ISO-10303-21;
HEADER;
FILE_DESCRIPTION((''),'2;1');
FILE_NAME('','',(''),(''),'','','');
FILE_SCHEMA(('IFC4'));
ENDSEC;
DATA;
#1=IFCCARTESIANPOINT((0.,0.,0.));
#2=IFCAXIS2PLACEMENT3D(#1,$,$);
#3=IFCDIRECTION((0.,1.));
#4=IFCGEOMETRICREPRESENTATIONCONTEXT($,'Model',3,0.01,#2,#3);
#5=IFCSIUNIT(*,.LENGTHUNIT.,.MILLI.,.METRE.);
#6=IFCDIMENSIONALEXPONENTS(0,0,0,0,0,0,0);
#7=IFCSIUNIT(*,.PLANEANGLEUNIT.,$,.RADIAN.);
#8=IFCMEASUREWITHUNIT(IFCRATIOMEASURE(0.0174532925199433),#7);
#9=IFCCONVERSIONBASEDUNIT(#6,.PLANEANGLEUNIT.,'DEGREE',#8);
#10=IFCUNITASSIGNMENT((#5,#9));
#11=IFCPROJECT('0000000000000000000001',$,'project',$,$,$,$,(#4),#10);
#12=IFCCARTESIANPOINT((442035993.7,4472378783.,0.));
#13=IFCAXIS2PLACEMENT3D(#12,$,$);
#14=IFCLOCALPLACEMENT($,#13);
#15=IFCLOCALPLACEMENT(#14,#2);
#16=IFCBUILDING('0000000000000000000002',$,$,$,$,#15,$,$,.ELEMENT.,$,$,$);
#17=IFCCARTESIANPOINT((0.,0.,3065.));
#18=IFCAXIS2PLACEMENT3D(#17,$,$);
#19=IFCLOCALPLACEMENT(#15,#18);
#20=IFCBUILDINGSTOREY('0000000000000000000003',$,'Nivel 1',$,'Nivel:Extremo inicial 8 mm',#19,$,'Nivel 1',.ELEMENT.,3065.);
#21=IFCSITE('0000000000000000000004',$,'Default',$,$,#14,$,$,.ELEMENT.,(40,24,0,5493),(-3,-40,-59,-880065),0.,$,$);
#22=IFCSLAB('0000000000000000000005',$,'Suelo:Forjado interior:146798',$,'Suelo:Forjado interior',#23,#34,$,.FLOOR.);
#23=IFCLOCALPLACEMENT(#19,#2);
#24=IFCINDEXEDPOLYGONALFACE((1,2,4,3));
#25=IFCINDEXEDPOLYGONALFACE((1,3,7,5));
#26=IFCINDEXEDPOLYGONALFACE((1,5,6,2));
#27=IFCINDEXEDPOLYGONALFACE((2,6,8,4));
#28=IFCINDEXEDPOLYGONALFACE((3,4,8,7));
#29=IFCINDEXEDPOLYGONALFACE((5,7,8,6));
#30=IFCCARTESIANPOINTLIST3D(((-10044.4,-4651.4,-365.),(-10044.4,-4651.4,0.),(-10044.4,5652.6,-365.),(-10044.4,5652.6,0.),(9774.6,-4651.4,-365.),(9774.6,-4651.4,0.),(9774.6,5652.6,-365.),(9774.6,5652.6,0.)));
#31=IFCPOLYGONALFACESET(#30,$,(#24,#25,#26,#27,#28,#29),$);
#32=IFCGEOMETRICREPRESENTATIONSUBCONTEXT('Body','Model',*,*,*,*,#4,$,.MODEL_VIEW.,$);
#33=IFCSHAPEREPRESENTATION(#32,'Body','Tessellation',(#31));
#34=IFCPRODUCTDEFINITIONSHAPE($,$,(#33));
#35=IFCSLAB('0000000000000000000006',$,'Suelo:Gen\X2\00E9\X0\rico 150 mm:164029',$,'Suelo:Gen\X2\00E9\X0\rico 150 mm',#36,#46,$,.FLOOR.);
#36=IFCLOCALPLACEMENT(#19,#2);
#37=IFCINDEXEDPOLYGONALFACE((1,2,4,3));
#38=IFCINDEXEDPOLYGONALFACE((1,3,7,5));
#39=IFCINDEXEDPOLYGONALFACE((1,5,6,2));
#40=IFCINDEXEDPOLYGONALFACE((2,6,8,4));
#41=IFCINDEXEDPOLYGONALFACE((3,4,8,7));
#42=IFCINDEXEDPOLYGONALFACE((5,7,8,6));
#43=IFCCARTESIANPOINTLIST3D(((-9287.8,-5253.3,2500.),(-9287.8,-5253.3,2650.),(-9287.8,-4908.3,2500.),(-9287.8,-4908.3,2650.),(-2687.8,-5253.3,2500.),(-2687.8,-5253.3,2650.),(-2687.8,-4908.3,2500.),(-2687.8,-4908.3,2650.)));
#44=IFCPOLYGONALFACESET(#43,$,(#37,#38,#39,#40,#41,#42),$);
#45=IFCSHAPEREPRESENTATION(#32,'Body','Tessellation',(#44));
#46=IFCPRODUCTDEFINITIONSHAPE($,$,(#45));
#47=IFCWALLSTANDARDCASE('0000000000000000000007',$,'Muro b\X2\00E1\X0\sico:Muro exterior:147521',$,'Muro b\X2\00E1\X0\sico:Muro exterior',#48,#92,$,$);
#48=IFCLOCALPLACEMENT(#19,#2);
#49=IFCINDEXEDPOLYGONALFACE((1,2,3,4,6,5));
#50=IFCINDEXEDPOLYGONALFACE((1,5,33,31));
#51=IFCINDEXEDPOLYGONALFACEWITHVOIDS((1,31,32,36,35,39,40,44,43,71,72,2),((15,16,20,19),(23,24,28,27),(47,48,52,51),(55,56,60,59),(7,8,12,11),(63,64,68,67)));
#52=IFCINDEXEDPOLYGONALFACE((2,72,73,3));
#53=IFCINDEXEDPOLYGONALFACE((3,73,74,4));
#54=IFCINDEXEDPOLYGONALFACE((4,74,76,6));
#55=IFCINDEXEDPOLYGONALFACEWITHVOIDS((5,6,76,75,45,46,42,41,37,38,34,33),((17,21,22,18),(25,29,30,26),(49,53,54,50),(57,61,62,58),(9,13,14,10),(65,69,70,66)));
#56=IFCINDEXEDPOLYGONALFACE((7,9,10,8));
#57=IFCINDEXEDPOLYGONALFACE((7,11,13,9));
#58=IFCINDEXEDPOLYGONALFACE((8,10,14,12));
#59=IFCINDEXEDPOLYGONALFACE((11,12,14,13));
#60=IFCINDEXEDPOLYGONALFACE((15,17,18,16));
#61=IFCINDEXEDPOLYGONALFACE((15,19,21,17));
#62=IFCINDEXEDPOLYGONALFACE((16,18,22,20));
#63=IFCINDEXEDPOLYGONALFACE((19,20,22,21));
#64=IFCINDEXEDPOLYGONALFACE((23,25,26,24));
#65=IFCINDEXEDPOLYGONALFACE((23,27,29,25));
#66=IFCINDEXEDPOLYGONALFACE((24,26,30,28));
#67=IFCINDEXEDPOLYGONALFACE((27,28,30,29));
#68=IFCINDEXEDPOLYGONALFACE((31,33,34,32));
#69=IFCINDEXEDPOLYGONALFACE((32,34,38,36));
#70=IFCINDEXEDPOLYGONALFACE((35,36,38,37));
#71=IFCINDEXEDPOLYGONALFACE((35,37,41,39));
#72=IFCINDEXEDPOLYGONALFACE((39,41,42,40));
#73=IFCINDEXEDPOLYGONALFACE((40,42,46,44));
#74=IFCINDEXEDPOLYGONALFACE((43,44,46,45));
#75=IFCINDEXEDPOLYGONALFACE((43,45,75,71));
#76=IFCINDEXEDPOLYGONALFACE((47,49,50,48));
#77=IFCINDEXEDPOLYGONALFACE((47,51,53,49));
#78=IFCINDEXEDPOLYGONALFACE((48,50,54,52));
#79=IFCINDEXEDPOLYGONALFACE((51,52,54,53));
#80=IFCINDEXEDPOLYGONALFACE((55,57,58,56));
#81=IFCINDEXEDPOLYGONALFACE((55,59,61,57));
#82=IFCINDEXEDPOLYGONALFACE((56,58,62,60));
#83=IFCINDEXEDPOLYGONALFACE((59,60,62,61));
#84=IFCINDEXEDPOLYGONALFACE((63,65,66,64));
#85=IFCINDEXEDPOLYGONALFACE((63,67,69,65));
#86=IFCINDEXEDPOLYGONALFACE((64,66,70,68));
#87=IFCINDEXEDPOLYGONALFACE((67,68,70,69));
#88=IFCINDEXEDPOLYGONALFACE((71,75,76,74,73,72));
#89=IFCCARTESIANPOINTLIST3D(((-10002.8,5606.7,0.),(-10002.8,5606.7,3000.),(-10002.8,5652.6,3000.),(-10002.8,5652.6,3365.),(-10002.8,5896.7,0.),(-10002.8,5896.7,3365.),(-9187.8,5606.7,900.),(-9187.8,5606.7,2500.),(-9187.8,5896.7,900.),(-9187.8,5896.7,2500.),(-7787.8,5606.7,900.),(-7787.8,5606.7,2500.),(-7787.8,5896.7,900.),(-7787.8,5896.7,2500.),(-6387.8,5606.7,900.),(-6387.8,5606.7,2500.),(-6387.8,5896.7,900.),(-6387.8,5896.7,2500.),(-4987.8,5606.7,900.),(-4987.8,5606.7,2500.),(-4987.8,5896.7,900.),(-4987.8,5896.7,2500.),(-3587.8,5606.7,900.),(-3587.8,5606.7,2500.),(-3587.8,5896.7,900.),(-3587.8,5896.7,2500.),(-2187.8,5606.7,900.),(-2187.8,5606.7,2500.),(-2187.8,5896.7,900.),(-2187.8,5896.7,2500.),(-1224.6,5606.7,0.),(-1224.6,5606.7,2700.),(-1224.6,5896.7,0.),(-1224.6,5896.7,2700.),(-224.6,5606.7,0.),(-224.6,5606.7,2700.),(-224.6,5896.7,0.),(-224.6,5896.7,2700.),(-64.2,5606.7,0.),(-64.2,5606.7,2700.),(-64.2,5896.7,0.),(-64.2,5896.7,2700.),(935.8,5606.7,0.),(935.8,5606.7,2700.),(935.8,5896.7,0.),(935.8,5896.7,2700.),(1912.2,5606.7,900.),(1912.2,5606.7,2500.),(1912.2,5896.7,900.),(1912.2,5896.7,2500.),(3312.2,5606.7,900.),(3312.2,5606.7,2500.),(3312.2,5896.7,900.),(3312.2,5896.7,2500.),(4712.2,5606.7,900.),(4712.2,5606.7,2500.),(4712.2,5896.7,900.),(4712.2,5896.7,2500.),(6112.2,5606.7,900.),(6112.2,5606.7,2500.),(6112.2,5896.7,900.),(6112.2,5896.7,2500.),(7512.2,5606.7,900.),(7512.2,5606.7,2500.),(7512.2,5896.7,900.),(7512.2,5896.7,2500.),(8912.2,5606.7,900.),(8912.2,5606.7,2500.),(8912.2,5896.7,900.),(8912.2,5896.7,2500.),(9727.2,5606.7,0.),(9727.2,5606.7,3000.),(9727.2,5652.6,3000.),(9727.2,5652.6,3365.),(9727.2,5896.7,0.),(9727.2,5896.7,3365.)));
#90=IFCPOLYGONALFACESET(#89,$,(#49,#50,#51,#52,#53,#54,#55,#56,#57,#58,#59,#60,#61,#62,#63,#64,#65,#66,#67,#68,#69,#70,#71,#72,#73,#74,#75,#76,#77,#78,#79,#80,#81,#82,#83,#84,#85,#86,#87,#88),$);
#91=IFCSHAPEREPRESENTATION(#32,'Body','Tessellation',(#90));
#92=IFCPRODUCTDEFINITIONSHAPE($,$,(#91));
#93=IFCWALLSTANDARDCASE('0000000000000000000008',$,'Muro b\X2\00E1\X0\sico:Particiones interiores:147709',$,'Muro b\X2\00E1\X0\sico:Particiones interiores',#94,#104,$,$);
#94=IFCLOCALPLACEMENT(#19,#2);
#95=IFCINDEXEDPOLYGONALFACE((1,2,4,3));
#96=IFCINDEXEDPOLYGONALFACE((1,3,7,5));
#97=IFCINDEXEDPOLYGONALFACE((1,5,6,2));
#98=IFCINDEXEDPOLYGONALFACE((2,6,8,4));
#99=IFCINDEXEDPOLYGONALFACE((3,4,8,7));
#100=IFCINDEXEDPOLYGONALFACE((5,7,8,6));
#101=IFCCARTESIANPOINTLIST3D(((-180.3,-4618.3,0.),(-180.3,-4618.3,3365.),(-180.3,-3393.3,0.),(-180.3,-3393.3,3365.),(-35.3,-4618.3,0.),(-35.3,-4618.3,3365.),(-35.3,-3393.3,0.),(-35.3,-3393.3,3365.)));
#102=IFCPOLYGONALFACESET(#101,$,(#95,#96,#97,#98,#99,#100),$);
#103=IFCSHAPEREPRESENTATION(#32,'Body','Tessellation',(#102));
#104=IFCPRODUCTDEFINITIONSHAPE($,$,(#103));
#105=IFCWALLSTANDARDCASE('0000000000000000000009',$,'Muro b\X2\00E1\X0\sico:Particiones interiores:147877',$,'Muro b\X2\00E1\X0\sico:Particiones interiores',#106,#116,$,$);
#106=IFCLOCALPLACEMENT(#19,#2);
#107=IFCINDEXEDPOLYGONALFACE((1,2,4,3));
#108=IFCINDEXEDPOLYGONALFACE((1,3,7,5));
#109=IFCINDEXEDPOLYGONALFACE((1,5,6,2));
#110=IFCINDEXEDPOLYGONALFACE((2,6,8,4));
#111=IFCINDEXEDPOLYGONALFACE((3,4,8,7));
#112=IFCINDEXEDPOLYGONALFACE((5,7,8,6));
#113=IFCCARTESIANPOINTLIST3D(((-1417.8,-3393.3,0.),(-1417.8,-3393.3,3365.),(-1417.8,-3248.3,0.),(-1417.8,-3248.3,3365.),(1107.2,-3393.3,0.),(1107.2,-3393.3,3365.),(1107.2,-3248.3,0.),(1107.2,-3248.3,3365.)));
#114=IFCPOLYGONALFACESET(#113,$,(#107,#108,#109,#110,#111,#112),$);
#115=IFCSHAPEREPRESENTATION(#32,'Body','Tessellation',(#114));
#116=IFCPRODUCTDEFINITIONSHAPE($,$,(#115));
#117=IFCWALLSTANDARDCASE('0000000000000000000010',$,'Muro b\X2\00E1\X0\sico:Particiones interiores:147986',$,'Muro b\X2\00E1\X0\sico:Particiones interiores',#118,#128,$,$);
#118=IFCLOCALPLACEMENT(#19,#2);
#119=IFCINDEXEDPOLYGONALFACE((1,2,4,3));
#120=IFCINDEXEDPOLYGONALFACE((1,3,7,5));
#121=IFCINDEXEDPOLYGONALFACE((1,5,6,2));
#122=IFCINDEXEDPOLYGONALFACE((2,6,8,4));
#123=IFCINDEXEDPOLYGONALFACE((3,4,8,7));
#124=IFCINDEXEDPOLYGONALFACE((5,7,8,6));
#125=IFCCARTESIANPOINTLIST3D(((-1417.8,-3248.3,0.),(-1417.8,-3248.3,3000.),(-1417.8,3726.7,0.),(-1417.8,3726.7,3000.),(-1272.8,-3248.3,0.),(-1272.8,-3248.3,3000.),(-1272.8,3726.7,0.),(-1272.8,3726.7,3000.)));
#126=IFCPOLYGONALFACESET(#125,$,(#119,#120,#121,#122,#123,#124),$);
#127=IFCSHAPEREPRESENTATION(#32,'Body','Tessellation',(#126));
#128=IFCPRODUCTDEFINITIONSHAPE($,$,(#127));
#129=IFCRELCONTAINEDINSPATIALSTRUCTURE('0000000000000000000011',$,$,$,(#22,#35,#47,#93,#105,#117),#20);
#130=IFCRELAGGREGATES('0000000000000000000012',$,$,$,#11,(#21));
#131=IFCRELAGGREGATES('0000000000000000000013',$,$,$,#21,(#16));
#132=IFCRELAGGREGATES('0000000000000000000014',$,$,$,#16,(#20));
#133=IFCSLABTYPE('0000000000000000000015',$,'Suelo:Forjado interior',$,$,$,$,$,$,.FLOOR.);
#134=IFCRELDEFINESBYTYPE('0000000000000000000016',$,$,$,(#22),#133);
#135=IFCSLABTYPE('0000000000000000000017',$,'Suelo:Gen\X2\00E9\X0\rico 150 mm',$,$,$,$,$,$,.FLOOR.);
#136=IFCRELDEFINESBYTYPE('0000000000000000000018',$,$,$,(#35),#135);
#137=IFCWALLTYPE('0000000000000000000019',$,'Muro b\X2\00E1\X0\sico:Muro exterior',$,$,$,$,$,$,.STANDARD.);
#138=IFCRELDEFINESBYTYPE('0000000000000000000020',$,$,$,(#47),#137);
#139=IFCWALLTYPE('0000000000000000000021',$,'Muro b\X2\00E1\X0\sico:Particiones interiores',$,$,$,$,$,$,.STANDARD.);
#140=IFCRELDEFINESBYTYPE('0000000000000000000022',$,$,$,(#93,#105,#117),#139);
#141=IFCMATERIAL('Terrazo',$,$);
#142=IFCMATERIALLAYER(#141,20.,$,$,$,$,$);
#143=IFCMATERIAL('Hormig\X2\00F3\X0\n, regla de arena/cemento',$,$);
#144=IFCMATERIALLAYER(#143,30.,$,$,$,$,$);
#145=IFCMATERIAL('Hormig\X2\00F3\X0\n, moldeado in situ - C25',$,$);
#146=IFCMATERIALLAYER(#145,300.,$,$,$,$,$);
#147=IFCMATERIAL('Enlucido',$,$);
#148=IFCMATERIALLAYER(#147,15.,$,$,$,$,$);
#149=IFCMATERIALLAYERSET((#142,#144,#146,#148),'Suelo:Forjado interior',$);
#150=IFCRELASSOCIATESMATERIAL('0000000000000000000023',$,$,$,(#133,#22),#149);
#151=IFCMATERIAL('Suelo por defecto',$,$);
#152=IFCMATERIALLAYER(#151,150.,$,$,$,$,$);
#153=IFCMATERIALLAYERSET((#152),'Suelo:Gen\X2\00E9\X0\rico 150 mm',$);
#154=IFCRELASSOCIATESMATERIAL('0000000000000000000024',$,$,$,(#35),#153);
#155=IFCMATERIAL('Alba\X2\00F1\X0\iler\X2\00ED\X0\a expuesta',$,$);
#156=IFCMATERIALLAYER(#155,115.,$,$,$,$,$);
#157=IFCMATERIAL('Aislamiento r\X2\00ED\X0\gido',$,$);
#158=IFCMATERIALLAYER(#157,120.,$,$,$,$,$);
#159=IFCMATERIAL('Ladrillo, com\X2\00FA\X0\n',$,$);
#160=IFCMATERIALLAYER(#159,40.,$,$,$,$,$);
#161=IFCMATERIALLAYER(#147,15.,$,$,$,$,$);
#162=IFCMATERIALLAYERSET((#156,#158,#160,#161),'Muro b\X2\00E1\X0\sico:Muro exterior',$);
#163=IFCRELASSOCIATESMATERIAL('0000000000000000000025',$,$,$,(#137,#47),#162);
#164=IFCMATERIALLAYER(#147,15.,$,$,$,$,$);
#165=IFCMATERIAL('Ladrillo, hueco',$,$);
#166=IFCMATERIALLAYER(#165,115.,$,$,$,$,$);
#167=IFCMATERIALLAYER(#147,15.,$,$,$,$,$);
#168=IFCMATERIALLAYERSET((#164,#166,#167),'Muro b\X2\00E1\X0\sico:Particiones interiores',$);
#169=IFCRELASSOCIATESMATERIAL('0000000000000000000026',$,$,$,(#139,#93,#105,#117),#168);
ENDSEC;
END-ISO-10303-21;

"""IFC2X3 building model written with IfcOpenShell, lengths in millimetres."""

from ifc_helpers import new_model, entity, si_unit, converted_unit, direction, frame, frame_2d, origin, origin_2d_with_axis, place, context, subcontext, project, spatial, polyline, rectangle, extrude, clip, bounded_halfspace, material, layer, layer_set, layer_usage, type_object, element, save


model = new_model("IFC2X3")

# Units and contexts
model_context = context("Model", 3, precision=0.01, world=origin(), true_north=direction((0.0, 1.0)))
body_context = subcontext(model_context, "Body", "Model", "MODEL_VIEW")
ifc_project = project(units=[si_unit("LENGTHUNIT", "METRE", prefix="MILLI"), converted_unit("PLANEANGLEUNIT", "DEGREE", entity("IfcRatioMeasure", 0.0174532925199433), si_unit("PLANEANGLEUNIT", "RADIAN"), dimensions=[0, 0, 0, 0, 0, 0, 0])], contexts=[model_context])

# Site, building, storey
site_placement = place(None, frame((442035993.7, 4472378783.0, 0.0)))
site = spatial("IfcSite", under=ifc_project, at=site_placement, Name="Default", CompositionType="ELEMENT", RefLatitude=(40, 24, 0, 5493), RefLongitude=(-3, -40, -59, -880065), RefElevation=0.0)
building_placement = place(site_placement, origin())
building = spatial("IfcBuilding", under=site, at=building_placement, CompositionType="ELEMENT")
storey_placement = place(building_placement, frame((0.0, 0.0, 3065.0)))
storey = spatial("IfcBuildingStorey", under=building, at=storey_placement, Name="Nivel 1", ObjectType="Nivel:Extremo inicial 8 mm", LongName="Nivel 1", CompositionType="ELEMENT", Elevation=3065.0)

# Slabs
ifc_material_1 = material(Name="Terrazo")
ifc_layer_1 = layer(ifc_material_1, 20.0)
ifc_material_2 = material(Name="Hormigón, regla de arena/cemento")
ifc_layer_2 = layer(ifc_material_2, 30.0)
ifc_material_3 = material(Name="Hormigón, moldeado in situ - C25")
ifc_layer_3 = layer(ifc_material_3, 300.0)
ifc_material_4 = material(Name="Enlucido")
ifc_layer_4 = layer(ifc_material_4, 15.0)
ifc_layer_set_1 = layer_set([ifc_layer_1, ifc_layer_2, ifc_layer_3, ifc_layer_4], Name="Suelo:Forjado interior")
ifc_layer_usage_1 = layer_usage(ifc_layer_set_1, "AXIS3", "POSITIVE", 0.0)
slab_type_1 = type_object("IfcSlabType", Name="Suelo:Forjado interior", PredefinedType="FLOOR", material=ifc_layer_set_1)
slab_1_placement = place(storey_placement, origin())
element("IfcSlab", 1, at=slab_1_placement, inside=storey, type_object=slab_type_1, material=ifc_layer_usage_1, Name="Suelo:Forjado interior:146798", ObjectType="Suelo:Forjado interior", PredefinedType="FLOOR", context=body_context, shape_type="SweptSolid", body=[
    extrude(rectangle(XDim=10304.0, YDim=19819.0, at=origin_2d_with_axis()), frame((-134.9, 500.6, 0.0), z_axis=(0.0, 0.0, -1.0), x_axis=(0.0, 1.0, 0.0)), (0.0, 0.0, 1.0), 365.0),
])
ifc_material_5 = material(Name="Suelo por defecto")
ifc_layer_5 = layer(ifc_material_5, 150.0)
ifc_layer_set_2 = layer_set([ifc_layer_5], Name="Suelo:Genérico 150 mm")
ifc_layer_usage_2 = layer_usage(ifc_layer_set_2, "AXIS3", "POSITIVE", 0.0)
slab_type_2 = type_object("IfcSlabType", Name="Suelo:Genérico 150 mm", PredefinedType="FLOOR")
slab_2_placement = place(storey_placement, frame((-9287.8, -5253.3, 2500.0)))
element("IfcSlab", 2, at=slab_2_placement, inside=storey, type_object=slab_type_2, material=ifc_layer_usage_2, Name="Suelo:Genérico 150 mm:164029", ObjectType="Suelo:Genérico 150 mm", PredefinedType="FLOOR", context=body_context, shape_type="SweptSolid", body=[
    extrude(rectangle(XDim=6600.0, YDim=345.0, at=frame_2d((5850.0, 0.0), x_axis=(1.0, 0.0))), frame((9150.0, 172.5, 150.0), z_axis=(0.0, 0.0, -1.0), x_axis=(-1.0, 0.0, 0.0)), (0.0, 0.0, 1.0), 150.0),
])

# Wall, openings
ifc_material_6 = material(Name="Albañilería expuesta")
ifc_layer_6 = layer(ifc_material_6, 115.0)
ifc_material_7 = material(Name="Aislamiento rígido")
ifc_layer_7 = layer(ifc_material_7, 120.0)
ifc_material_8 = material(Name="Ladrillo, común")
ifc_layer_8 = layer(ifc_material_8, 40.0)
ifc_layer_9 = layer(ifc_material_4, 15.0)
ifc_layer_set_3 = layer_set([ifc_layer_6, ifc_layer_7, ifc_layer_8, ifc_layer_9], Name="Muro básico:Muro exterior")
ifc_layer_usage_3 = layer_usage(ifc_layer_set_3, "AXIS2", "NEGATIVE", 145.0)
wall_type_1 = type_object("IfcWallType", Name="Muro básico:Muro exterior", PredefinedType="STANDARD", material=ifc_layer_set_3)
wall_1_placement = place(storey_placement, frame((-10002.8, 5751.7, 0.0)))
wall_1 = element("IfcWallStandardCase", 3, at=wall_1_placement, inside=storey, type_object=wall_type_1, material=ifc_layer_usage_3, Name="Muro básico:Muro exterior:147521", ObjectType="Muro básico:Muro exterior", context=body_context, shape_type="Clipping", body=[
    clip(clip(extrude(rectangle(XDim=19730.0, YDim=290.0, at=frame_2d((9865.0, 0.0), x_axis=(-1.0, 0.0))), origin(), (0.0, 0.0, 1.0), 3365.0), bounded_halfspace(frame((19730.0, -99.2, 3000.0), z_axis=(0.0, 0.0, -1.0), x_axis=(-1.0, 0.0, 0.0)), True, frame((19730.0, -99.2, 3000.0), z_axis=(0.0, 0.0, -1.0), x_axis=(-1.0, 0.0, 0.0)), polyline([(0.0, 0.0), (0.0, -45.8), (9791.4, -45.8), (9936.4, -45.8), (19730.0, -45.8), (19730.0, 0.0), (0.0, 0.0)]))), bounded_halfspace(frame((0.0, -99.2, 3000.0), z_axis=(0.0, 1.0, 0.0), x_axis=(0.0, 0.0, 1.0)), True, frame((0.0, -99.2, 3000.0), z_axis=(0.0, 1.0, 0.0), x_axis=(0.0, 0.0, 1.0)), polyline([(0.0, 0.0), (365.0, 0.0), (365.0, 19730.0), (0.0, 19730.0), (0.0, 0.0)]))),
])
opening_1_placement = place(wall_1_placement, origin())
element("IfcOpeningElement", 4, at=opening_1_placement, cuts=wall_1, ObjectType="Opening", context=body_context, shape_type="SweptSolid", body=[
    extrude(rectangle(XDim=2700.0, YDim=1000.0, at=frame_2d((0.0, 0.0), x_axis=(1.0, 0.0))), frame((10438.6, -1669.0, 1350.0), z_axis=(0.0, 1.0, 0.0), x_axis=(0.0, 0.0, 1.0)), (0.0, 0.0, 1.0), 3048.0),
])
opening_2_placement = place(wall_1_placement, origin())
element("IfcOpeningElement", 5, at=opening_2_placement, cuts=wall_1, ObjectType="Opening", context=body_context, shape_type="SweptSolid", body=[
    extrude(rectangle(XDim=2700.0, YDim=1000.0, at=frame_2d((0.0, 0.0), x_axis=(1.0, 0.0))), frame((9278.2, -1669.0, 1350.0), z_axis=(0.0, 1.0, 0.0), x_axis=(0.0, 0.0, 1.0)), (0.0, 0.0, 1.0), 3048.0),
])
opening_3_placement = place(wall_1_placement, frame((18915.0, 145.0, 900.0)))
element("IfcOpeningElement", 6, at=opening_3_placement, cuts=wall_1, ObjectType="Opening", context=body_context, shape_type="SweptSolid", body=[
    extrude(rectangle(XDim=1600.0, YDim=1400.0, at=frame_2d((800.0, 700.0), x_axis=(1.0, 0.0))), frame((0.0, 0.0, 0.0), z_axis=(0.0, -1.0, 0.0), x_axis=(0.0, 0.0, 1.0)), (0.0, 0.0, 1.0), 290.0),
])
opening_4_placement = place(wall_1_placement, frame((16115.0, 145.0, 900.0)))
element("IfcOpeningElement", 7, at=opening_4_placement, cuts=wall_1, ObjectType="Opening", context=body_context, shape_type="SweptSolid", body=[
    extrude(rectangle(XDim=1600.0, YDim=1400.0, at=frame_2d((800.0, 700.0), x_axis=(1.0, 0.0))), frame((0.0, 0.0, 0.0), z_axis=(0.0, -1.0, 0.0), x_axis=(0.0, 0.0, 1.0)), (0.0, 0.0, 1.0), 290.0),
])
opening_5_placement = place(wall_1_placement, frame((13315.0, 145.0, 900.0)))
element("IfcOpeningElement", 8, at=opening_5_placement, cuts=wall_1, ObjectType="Opening", context=body_context, shape_type="SweptSolid", body=[
    extrude(rectangle(XDim=1600.0, YDim=1400.0, at=frame_2d((800.0, 700.0), x_axis=(1.0, 0.0))), frame((0.0, 0.0, 0.0), z_axis=(0.0, -1.0, 0.0), x_axis=(0.0, 0.0, 1.0)), (0.0, 0.0, 1.0), 290.0),
])
opening_6_placement = place(wall_1_placement, frame((7815.0, 145.0, 900.0)))
element("IfcOpeningElement", 9, at=opening_6_placement, cuts=wall_1, ObjectType="Opening", context=body_context, shape_type="SweptSolid", body=[
    extrude(rectangle(XDim=1600.0, YDim=1400.0, at=frame_2d((800.0, 700.0), x_axis=(1.0, 0.0))), frame((0.0, 0.0, 0.0), z_axis=(0.0, -1.0, 0.0), x_axis=(0.0, 0.0, 1.0)), (0.0, 0.0, 1.0), 290.0),
])
opening_7_placement = place(wall_1_placement, frame((5015.0, 145.0, 900.0)))
element("IfcOpeningElement", 10, at=opening_7_placement, cuts=wall_1, ObjectType="Opening", context=body_context, shape_type="SweptSolid", body=[
    extrude(rectangle(XDim=1600.0, YDim=1400.0, at=frame_2d((800.0, 700.0), x_axis=(1.0, 0.0))), frame((0.0, 0.0, 0.0), z_axis=(0.0, -1.0, 0.0), x_axis=(0.0, 0.0, 1.0)), (0.0, 0.0, 1.0), 290.0),
])
opening_8_placement = place(wall_1_placement, frame((2215.0, 145.0, 900.0)))
element("IfcOpeningElement", 11, at=opening_8_placement, cuts=wall_1, ObjectType="Opening", context=body_context, shape_type="SweptSolid", body=[
    extrude(rectangle(XDim=1600.0, YDim=1400.0, at=frame_2d((800.0, 700.0), x_axis=(1.0, 0.0))), frame((0.0, 0.0, 0.0), z_axis=(0.0, -1.0, 0.0), x_axis=(0.0, 0.0, 1.0)), (0.0, 0.0, 1.0), 290.0),
])
opening_9_placement = place(wall_1_placement, frame((8778.2, -145.0, 3365.0)))
element("IfcOpeningElement", 12, at=opening_9_placement, cuts=wall_1, ObjectType="Opening", context=body_context, shape_type="SweptSolid", body=[
    extrude(rectangle(XDim=2700.0, YDim=1000.0, at=frame_2d((1350.0, 500.0), x_axis=(1.0, 0.0))), frame((0.0, 0.0, 0.0), z_axis=(0.0, 1.0, 0.0), x_axis=(0.0, 0.0, 1.0)), (0.0, 0.0, 1.0), 290.0),
])
opening_10_placement = place(wall_1_placement, frame((9938.6, -145.0, 3365.0)))
element("IfcOpeningElement", 13, at=opening_10_placement, cuts=wall_1, ObjectType="Opening", context=body_context, shape_type="SweptSolid", body=[
    extrude(rectangle(XDim=2700.0, YDim=1000.0, at=frame_2d((1350.0, 500.0), x_axis=(1.0, 0.0))), frame((0.0, 0.0, 0.0), z_axis=(0.0, 1.0, 0.0), x_axis=(0.0, 0.0, 1.0)), (0.0, 0.0, 1.0), 290.0),
])

# Walls
ifc_layer_10 = layer(ifc_material_4, 15.0)
ifc_material_9 = material(Name="Ladrillo, hueco")
ifc_layer_11 = layer(ifc_material_9, 115.0)
ifc_layer_12 = layer(ifc_material_4, 15.0)
ifc_layer_set_4 = layer_set([ifc_layer_10, ifc_layer_11, ifc_layer_12], Name="Muro básico:Particiones interiores")
ifc_layer_usage_4 = layer_usage(ifc_layer_set_4, "AXIS2", "NEGATIVE", 72.5)
wall_type_2 = type_object("IfcWallType", Name="Muro básico:Particiones interiores", PredefinedType="STANDARD", material=ifc_layer_set_4)
wall_2_placement = place(storey_placement, frame((-107.8, -4618.3, 0.0), z_axis=(0.0, 0.0, 1.0), x_axis=(0.0, 1.0, 0.0)))
element("IfcWallStandardCase", 14, at=wall_2_placement, inside=storey, type_object=wall_type_2, material=ifc_layer_usage_4, Name="Muro básico:Particiones interiores:147709", ObjectType="Muro básico:Particiones interiores", context=body_context, shape_type="SweptSolid", body=[
    extrude(rectangle(XDim=1225.0, YDim=145.0, at=frame_2d((612.5, 0.0), x_axis=(-1.0, 0.0))), origin(), (0.0, 0.0, 1.0), 3365.0),
])
ifc_layer_usage_5 = layer_usage(ifc_layer_set_4, "AXIS2", "NEGATIVE", 72.5)
wall_3_placement = place(storey_placement, frame((1107.2, -3320.8, 0.0), z_axis=(0.0, 0.0, 1.0), x_axis=(-1.0, 0.0, 0.0)))
element("IfcWallStandardCase", 15, at=wall_3_placement, inside=storey, type_object=wall_type_2, material=ifc_layer_usage_5, Name="Muro básico:Particiones interiores:147877", ObjectType="Muro básico:Particiones interiores", context=body_context, shape_type="SweptSolid", body=[
    extrude(rectangle(XDim=2525.0, YDim=145.0, at=frame_2d((1262.5, 0.0), x_axis=(-1.0, 0.0))), origin(), (0.0, 0.0, 1.0), 3365.0),
])
ifc_layer_usage_6 = layer_usage(ifc_layer_set_4, "AXIS2", "NEGATIVE", 72.5)
wall_4_placement = place(storey_placement, frame((-1345.3, -3248.3, 0.0), z_axis=(0.0, 0.0, 1.0), x_axis=(0.0, 1.0, 0.0)))
element("IfcWallStandardCase", 16, at=wall_4_placement, inside=storey, type_object=wall_type_2, material=ifc_layer_usage_6, Name="Muro básico:Particiones interiores:147986", ObjectType="Muro básico:Particiones interiores", context=body_context, shape_type="Clipping", body=[
    clip(extrude(rectangle(XDim=6975.0, YDim=145.0, at=frame_2d((3487.5, 0.0), x_axis=(-1.0, 0.0))), origin(), (0.0, 0.0, 1.0), 3000.0), bounded_halfspace(frame((0.0, -72.5, 3000.0), z_axis=(0.0, 0.0, -1.0), x_axis=(0.0, 1.0, 0.0)), True, frame((0.0, -72.5, 3000.0), z_axis=(0.0, 0.0, -1.0), x_axis=(0.0, 1.0, 0.0)), polyline([(0.0, 0.0), (145.0, 0.0), (145.0, 6975.0), (0.0, 6975.0), (0.0, 0.0)]))),
])

save(model, "model.ifc")
